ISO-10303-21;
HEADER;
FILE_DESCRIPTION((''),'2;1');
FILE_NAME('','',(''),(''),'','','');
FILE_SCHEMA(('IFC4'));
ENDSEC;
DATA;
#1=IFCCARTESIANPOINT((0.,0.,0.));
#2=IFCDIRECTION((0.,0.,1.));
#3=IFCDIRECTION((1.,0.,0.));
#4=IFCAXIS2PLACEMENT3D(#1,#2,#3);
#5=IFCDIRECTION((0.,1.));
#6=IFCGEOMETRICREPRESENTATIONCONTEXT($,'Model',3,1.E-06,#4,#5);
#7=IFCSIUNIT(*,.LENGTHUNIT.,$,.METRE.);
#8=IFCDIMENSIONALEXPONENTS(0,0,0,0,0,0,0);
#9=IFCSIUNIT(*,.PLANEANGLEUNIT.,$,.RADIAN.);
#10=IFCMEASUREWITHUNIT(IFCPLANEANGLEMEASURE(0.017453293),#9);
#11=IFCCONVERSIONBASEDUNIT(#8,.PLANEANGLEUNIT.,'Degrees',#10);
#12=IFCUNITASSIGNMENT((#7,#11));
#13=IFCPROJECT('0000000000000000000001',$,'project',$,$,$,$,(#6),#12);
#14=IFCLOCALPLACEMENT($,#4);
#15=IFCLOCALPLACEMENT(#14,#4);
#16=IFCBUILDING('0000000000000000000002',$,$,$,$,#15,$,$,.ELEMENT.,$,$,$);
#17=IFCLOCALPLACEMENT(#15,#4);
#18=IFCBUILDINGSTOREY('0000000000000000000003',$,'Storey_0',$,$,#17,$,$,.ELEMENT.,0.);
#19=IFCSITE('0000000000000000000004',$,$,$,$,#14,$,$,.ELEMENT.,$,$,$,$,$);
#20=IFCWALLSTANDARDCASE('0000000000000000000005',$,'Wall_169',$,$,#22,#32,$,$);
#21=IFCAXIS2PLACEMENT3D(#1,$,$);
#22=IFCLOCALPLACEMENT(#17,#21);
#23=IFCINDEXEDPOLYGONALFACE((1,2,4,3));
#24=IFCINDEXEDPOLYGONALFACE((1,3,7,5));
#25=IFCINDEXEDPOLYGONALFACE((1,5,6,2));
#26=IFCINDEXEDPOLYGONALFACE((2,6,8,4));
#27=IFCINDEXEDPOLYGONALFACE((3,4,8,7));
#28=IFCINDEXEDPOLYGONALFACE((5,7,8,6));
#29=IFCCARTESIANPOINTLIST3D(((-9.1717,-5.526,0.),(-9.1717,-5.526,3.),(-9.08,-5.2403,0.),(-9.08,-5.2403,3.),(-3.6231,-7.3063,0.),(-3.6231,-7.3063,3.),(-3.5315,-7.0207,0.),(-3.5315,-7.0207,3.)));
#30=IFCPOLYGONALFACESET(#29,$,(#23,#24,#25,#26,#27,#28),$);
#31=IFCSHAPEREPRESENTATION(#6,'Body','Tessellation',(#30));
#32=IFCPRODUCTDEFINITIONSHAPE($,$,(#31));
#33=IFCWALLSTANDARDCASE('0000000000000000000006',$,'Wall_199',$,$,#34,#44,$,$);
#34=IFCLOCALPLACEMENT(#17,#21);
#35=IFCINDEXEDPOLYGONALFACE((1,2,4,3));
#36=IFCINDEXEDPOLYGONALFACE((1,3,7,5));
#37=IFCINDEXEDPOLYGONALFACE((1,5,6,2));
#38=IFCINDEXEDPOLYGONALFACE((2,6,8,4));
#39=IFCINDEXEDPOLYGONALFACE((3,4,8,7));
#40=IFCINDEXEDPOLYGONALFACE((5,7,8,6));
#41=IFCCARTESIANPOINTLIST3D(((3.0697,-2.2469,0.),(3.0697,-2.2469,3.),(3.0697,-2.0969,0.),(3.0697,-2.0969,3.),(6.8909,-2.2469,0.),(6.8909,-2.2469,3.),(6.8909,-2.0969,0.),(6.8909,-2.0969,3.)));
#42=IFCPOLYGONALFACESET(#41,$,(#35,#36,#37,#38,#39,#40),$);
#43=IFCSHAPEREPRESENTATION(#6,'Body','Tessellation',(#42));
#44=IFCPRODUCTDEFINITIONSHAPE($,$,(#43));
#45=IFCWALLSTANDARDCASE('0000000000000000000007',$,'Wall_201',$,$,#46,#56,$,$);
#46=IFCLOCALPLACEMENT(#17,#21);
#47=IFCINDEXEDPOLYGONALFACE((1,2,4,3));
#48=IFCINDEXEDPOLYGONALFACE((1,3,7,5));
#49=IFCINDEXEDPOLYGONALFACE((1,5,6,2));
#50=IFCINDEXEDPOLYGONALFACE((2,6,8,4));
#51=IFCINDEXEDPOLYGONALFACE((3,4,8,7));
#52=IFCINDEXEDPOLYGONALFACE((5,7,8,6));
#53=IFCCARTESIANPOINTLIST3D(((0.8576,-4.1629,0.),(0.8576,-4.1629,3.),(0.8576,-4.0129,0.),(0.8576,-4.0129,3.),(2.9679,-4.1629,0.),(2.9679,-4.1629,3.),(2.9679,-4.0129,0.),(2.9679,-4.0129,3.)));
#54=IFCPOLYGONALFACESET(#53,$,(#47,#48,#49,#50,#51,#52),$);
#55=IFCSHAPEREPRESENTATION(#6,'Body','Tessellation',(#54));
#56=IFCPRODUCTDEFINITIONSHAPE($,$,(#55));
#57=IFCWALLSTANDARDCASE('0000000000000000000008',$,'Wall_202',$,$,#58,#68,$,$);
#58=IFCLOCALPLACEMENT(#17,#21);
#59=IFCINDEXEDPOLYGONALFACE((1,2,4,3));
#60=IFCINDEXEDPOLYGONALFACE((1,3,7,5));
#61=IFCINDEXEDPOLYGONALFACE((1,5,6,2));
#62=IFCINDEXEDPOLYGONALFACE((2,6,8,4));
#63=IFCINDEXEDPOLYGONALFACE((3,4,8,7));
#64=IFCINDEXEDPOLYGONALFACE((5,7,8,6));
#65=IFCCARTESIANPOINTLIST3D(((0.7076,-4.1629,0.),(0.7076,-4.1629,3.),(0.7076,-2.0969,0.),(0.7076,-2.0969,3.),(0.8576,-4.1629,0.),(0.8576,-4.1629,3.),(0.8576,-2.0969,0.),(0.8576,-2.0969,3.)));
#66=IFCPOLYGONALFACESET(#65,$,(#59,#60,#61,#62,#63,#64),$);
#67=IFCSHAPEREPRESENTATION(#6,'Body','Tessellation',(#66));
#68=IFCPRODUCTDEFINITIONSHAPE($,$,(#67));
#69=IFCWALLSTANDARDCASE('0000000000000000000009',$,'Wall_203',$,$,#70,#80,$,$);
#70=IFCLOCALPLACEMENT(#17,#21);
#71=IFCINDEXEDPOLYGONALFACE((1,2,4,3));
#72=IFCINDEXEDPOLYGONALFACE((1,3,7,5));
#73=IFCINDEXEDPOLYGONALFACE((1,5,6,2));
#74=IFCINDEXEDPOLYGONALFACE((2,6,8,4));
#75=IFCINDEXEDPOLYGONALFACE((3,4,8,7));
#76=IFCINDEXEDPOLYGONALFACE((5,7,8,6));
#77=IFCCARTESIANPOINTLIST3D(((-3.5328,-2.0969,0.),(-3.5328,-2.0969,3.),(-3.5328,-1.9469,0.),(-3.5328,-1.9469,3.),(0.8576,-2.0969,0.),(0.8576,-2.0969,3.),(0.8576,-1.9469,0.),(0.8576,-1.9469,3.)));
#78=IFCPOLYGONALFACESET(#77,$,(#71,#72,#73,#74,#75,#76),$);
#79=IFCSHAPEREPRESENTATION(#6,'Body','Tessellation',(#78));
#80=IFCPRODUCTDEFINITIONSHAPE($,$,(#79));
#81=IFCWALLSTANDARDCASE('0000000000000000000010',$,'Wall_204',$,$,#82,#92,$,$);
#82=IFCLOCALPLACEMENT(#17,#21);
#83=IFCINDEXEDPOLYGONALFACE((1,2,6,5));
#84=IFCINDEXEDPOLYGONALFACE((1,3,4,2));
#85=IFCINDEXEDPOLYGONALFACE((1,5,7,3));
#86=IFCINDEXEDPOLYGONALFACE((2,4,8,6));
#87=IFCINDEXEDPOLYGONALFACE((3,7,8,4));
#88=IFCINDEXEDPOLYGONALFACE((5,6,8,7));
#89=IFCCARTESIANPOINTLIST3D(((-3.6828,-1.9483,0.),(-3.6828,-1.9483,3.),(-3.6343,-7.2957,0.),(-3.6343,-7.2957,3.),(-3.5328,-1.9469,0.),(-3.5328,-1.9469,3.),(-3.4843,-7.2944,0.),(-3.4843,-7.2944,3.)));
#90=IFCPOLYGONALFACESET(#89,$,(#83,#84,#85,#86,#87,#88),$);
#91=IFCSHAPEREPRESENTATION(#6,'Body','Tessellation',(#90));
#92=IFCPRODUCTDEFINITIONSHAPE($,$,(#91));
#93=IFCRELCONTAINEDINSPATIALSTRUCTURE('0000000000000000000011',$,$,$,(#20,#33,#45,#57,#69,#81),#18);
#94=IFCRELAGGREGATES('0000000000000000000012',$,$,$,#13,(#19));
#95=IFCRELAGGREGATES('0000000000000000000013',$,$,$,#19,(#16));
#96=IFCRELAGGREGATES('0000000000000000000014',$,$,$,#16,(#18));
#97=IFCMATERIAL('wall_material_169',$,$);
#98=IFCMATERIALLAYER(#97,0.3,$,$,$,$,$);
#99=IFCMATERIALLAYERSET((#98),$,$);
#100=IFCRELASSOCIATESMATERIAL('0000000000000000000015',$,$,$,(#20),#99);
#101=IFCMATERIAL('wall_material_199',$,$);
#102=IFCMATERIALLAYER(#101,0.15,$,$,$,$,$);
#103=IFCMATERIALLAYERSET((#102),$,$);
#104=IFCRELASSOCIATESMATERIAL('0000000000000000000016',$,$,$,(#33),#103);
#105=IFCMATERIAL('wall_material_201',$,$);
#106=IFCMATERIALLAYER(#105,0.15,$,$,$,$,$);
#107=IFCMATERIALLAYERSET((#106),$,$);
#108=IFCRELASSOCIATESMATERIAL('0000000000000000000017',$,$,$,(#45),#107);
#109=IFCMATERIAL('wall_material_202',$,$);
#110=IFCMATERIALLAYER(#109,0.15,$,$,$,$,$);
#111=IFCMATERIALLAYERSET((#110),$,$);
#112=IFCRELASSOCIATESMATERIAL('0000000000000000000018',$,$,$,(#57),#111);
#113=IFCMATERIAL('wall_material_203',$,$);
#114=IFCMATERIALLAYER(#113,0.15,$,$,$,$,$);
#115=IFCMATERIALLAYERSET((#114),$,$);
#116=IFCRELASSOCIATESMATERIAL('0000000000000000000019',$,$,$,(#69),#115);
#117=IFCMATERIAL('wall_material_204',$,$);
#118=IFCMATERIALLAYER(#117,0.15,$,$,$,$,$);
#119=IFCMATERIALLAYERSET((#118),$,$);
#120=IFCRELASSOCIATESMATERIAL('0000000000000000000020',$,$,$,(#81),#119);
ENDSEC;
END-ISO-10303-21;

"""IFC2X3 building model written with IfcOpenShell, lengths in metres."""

from ifc_helpers import new_model, entity, si_unit, converted_unit, direction, frame, origin_with_axes, place, context, project, spatial, polyline, outline, extrude, material, layer, layer_set, layer_usage, element, save


model = new_model("IFC2X3")

# Units and contexts
model_context = context("Model", 3, precision=1e-06, world=origin_with_axes(), true_north=direction((0.0, 1.0)))
ifc_project = project(units=[si_unit("LENGTHUNIT", "METRE"), converted_unit("PLANEANGLEUNIT", "Degrees", entity("IfcPlaneAngleMeasure", 0.017453293), si_unit("PLANEANGLEUNIT", "RADIAN"), dimensions=[0, 0, 0, 0, 0, 0, 0])], contexts=[model_context])

# Site, building, storey
site_placement = place(None, origin_with_axes())
site = spatial("IfcSite", under=ifc_project, at=site_placement, CompositionType="ELEMENT")
building_placement = place(site_placement, origin_with_axes())
building = spatial("IfcBuilding", under=site, at=building_placement, CompositionType="ELEMENT")
storey_placement = place(building_placement, origin_with_axes())
storey = spatial("IfcBuildingStorey", under=building, at=storey_placement, Name="Storey_0", CompositionType="ELEMENT", Elevation=0.0)

# Walls
ifc_material_1 = material(Name="wall_material_169")
ifc_layer_1 = layer(ifc_material_1, 0.3)
ifc_layer_set_1 = layer_set([ifc_layer_1])
ifc_layer_usage_1 = layer_usage(ifc_layer_set_1, "AXIS2", "NEGATIVE", 0.0)
wall_1_placement = place(storey_placement, frame((-3.6231, -7.3063, 0.0), z_axis=(0.0, 0.0, 1.0), x_axis=(-0.952183, 0.305529, 0.0)))
element("IfcWallStandardCase", 1, at=wall_1_placement, inside=storey, material=ifc_layer_usage_1, Name="Wall_169", context=model_context, shape_type="SweptSolid", body=[
    extrude(outline(polyline([(0.0, 0.0), (5.8272, 0.0), (5.8272, -0.3), (0.0, -0.3), (0.0, 0.0)])), origin_with_axes(), (0.0, 0.0, 1.0), 3.0),
])
ifc_material_2 = material(Name="wall_material_199")
ifc_layer_2 = layer(ifc_material_2, 0.15)
ifc_layer_set_2 = layer_set([ifc_layer_2])
ifc_layer_usage_2 = layer_usage(ifc_layer_set_2, "AXIS2", "NEGATIVE", 0.0)
wall_2_placement = place(storey_placement, frame((3.0697, -2.0969, 0.0), z_axis=(0.0, 0.0, 1.0), x_axis=(1.0, 0.0, 0.0)))
element("IfcWallStandardCase", 2, at=wall_2_placement, inside=storey, material=ifc_layer_usage_2, Name="Wall_199", context=model_context, shape_type="SweptSolid", body=[
    extrude(outline(polyline([(0.0, 0.0), (3.8212, 0.0), (3.8212, -0.15), (0.0, -0.15), (0.0, 0.0)])), origin_with_axes(), (0.0, 0.0, 1.0), 3.0),
])
ifc_material_3 = material(Name="wall_material_201")
ifc_layer_3 = layer(ifc_material_3, 0.15)
ifc_layer_set_3 = layer_set([ifc_layer_3])
ifc_layer_usage_3 = layer_usage(ifc_layer_set_3, "AXIS2", "NEGATIVE", 0.0)
wall_3_placement = place(storey_placement, frame((2.9679, -4.1629, 0.0), z_axis=(0.0, 0.0, 1.0), x_axis=(-1.0, 0.0, 0.0)))
element("IfcWallStandardCase", 3, at=wall_3_placement, inside=storey, material=ifc_layer_usage_3, Name="Wall_201", context=model_context, shape_type="SweptSolid", body=[
    extrude(outline(polyline([(0.0, 0.0), (2.1103, 0.0), (2.1103, -0.15), (0.0, -0.15), (0.0, 0.0)])), origin_with_axes(), (0.0, 0.0, 1.0), 3.0),
])
ifc_material_4 = material(Name="wall_material_202")
ifc_layer_4 = layer(ifc_material_4, 0.15)
ifc_layer_set_4 = layer_set([ifc_layer_4])
ifc_layer_usage_4 = layer_usage(ifc_layer_set_4, "AXIS2", "NEGATIVE", 0.0)
wall_4_placement = place(storey_placement, frame((0.7076, -4.1629, 0.0), z_axis=(0.0, 0.0, 1.0), x_axis=(0.0, 1.0, 0.0)))
element("IfcWallStandardCase", 4, at=wall_4_placement, inside=storey, material=ifc_layer_usage_4, Name="Wall_202", context=model_context, shape_type="SweptSolid", body=[
    extrude(outline(polyline([(0.0, 0.0), (2.066, 0.0), (2.066, -0.15), (0.0, -0.15), (0.0, 0.0)])), origin_with_axes(), (0.0, 0.0, 1.0), 3.0),
])
ifc_material_5 = material(Name="wall_material_203")
ifc_layer_5 = layer(ifc_material_5, 0.15)
ifc_layer_set_5 = layer_set([ifc_layer_5])
ifc_layer_usage_5 = layer_usage(ifc_layer_set_5, "AXIS2", "NEGATIVE", 0.0)
wall_5_placement = place(storey_placement, frame((0.8576, -2.0969, 0.0), z_axis=(0.0, 0.0, 1.0), x_axis=(-1.0, 0.0, 0.0)))
element("IfcWallStandardCase", 5, at=wall_5_placement, inside=storey, material=ifc_layer_usage_5, Name="Wall_203", context=model_context, shape_type="SweptSolid", body=[
    extrude(outline(polyline([(0.0, 0.0), (4.3904, 0.0), (4.3904, -0.15), (0.0, -0.15), (0.0, 0.0)])), origin_with_axes(), (0.0, 0.0, 1.0), 3.0),
])
ifc_material_6 = material(Name="wall_material_204")
ifc_layer_6 = layer(ifc_material_6, 0.15)
ifc_layer_set_6 = layer_set([ifc_layer_6])
ifc_layer_usage_6 = layer_usage(ifc_layer_set_6, "AXIS2", "NEGATIVE", 0.0)
wall_6_placement = place(storey_placement, frame((-3.5328, -1.9469, 0.0), z_axis=(0.0, 0.0, 1.0), x_axis=(0.009076, -0.999959, 0.0)))
element("IfcWallStandardCase", 6, at=wall_6_placement, inside=storey, material=ifc_layer_usage_6, Name="Wall_204", context=model_context, shape_type="SweptSolid", body=[
    extrude(outline(polyline([(0.0, 0.0), (5.3477, 0.0), (5.3477, -0.15), (0.0, -0.15), (0.0, 0.0)])), origin_with_axes(), (0.0, 0.0, 1.0), 3.0),
])

save(model, "model.ifc")
